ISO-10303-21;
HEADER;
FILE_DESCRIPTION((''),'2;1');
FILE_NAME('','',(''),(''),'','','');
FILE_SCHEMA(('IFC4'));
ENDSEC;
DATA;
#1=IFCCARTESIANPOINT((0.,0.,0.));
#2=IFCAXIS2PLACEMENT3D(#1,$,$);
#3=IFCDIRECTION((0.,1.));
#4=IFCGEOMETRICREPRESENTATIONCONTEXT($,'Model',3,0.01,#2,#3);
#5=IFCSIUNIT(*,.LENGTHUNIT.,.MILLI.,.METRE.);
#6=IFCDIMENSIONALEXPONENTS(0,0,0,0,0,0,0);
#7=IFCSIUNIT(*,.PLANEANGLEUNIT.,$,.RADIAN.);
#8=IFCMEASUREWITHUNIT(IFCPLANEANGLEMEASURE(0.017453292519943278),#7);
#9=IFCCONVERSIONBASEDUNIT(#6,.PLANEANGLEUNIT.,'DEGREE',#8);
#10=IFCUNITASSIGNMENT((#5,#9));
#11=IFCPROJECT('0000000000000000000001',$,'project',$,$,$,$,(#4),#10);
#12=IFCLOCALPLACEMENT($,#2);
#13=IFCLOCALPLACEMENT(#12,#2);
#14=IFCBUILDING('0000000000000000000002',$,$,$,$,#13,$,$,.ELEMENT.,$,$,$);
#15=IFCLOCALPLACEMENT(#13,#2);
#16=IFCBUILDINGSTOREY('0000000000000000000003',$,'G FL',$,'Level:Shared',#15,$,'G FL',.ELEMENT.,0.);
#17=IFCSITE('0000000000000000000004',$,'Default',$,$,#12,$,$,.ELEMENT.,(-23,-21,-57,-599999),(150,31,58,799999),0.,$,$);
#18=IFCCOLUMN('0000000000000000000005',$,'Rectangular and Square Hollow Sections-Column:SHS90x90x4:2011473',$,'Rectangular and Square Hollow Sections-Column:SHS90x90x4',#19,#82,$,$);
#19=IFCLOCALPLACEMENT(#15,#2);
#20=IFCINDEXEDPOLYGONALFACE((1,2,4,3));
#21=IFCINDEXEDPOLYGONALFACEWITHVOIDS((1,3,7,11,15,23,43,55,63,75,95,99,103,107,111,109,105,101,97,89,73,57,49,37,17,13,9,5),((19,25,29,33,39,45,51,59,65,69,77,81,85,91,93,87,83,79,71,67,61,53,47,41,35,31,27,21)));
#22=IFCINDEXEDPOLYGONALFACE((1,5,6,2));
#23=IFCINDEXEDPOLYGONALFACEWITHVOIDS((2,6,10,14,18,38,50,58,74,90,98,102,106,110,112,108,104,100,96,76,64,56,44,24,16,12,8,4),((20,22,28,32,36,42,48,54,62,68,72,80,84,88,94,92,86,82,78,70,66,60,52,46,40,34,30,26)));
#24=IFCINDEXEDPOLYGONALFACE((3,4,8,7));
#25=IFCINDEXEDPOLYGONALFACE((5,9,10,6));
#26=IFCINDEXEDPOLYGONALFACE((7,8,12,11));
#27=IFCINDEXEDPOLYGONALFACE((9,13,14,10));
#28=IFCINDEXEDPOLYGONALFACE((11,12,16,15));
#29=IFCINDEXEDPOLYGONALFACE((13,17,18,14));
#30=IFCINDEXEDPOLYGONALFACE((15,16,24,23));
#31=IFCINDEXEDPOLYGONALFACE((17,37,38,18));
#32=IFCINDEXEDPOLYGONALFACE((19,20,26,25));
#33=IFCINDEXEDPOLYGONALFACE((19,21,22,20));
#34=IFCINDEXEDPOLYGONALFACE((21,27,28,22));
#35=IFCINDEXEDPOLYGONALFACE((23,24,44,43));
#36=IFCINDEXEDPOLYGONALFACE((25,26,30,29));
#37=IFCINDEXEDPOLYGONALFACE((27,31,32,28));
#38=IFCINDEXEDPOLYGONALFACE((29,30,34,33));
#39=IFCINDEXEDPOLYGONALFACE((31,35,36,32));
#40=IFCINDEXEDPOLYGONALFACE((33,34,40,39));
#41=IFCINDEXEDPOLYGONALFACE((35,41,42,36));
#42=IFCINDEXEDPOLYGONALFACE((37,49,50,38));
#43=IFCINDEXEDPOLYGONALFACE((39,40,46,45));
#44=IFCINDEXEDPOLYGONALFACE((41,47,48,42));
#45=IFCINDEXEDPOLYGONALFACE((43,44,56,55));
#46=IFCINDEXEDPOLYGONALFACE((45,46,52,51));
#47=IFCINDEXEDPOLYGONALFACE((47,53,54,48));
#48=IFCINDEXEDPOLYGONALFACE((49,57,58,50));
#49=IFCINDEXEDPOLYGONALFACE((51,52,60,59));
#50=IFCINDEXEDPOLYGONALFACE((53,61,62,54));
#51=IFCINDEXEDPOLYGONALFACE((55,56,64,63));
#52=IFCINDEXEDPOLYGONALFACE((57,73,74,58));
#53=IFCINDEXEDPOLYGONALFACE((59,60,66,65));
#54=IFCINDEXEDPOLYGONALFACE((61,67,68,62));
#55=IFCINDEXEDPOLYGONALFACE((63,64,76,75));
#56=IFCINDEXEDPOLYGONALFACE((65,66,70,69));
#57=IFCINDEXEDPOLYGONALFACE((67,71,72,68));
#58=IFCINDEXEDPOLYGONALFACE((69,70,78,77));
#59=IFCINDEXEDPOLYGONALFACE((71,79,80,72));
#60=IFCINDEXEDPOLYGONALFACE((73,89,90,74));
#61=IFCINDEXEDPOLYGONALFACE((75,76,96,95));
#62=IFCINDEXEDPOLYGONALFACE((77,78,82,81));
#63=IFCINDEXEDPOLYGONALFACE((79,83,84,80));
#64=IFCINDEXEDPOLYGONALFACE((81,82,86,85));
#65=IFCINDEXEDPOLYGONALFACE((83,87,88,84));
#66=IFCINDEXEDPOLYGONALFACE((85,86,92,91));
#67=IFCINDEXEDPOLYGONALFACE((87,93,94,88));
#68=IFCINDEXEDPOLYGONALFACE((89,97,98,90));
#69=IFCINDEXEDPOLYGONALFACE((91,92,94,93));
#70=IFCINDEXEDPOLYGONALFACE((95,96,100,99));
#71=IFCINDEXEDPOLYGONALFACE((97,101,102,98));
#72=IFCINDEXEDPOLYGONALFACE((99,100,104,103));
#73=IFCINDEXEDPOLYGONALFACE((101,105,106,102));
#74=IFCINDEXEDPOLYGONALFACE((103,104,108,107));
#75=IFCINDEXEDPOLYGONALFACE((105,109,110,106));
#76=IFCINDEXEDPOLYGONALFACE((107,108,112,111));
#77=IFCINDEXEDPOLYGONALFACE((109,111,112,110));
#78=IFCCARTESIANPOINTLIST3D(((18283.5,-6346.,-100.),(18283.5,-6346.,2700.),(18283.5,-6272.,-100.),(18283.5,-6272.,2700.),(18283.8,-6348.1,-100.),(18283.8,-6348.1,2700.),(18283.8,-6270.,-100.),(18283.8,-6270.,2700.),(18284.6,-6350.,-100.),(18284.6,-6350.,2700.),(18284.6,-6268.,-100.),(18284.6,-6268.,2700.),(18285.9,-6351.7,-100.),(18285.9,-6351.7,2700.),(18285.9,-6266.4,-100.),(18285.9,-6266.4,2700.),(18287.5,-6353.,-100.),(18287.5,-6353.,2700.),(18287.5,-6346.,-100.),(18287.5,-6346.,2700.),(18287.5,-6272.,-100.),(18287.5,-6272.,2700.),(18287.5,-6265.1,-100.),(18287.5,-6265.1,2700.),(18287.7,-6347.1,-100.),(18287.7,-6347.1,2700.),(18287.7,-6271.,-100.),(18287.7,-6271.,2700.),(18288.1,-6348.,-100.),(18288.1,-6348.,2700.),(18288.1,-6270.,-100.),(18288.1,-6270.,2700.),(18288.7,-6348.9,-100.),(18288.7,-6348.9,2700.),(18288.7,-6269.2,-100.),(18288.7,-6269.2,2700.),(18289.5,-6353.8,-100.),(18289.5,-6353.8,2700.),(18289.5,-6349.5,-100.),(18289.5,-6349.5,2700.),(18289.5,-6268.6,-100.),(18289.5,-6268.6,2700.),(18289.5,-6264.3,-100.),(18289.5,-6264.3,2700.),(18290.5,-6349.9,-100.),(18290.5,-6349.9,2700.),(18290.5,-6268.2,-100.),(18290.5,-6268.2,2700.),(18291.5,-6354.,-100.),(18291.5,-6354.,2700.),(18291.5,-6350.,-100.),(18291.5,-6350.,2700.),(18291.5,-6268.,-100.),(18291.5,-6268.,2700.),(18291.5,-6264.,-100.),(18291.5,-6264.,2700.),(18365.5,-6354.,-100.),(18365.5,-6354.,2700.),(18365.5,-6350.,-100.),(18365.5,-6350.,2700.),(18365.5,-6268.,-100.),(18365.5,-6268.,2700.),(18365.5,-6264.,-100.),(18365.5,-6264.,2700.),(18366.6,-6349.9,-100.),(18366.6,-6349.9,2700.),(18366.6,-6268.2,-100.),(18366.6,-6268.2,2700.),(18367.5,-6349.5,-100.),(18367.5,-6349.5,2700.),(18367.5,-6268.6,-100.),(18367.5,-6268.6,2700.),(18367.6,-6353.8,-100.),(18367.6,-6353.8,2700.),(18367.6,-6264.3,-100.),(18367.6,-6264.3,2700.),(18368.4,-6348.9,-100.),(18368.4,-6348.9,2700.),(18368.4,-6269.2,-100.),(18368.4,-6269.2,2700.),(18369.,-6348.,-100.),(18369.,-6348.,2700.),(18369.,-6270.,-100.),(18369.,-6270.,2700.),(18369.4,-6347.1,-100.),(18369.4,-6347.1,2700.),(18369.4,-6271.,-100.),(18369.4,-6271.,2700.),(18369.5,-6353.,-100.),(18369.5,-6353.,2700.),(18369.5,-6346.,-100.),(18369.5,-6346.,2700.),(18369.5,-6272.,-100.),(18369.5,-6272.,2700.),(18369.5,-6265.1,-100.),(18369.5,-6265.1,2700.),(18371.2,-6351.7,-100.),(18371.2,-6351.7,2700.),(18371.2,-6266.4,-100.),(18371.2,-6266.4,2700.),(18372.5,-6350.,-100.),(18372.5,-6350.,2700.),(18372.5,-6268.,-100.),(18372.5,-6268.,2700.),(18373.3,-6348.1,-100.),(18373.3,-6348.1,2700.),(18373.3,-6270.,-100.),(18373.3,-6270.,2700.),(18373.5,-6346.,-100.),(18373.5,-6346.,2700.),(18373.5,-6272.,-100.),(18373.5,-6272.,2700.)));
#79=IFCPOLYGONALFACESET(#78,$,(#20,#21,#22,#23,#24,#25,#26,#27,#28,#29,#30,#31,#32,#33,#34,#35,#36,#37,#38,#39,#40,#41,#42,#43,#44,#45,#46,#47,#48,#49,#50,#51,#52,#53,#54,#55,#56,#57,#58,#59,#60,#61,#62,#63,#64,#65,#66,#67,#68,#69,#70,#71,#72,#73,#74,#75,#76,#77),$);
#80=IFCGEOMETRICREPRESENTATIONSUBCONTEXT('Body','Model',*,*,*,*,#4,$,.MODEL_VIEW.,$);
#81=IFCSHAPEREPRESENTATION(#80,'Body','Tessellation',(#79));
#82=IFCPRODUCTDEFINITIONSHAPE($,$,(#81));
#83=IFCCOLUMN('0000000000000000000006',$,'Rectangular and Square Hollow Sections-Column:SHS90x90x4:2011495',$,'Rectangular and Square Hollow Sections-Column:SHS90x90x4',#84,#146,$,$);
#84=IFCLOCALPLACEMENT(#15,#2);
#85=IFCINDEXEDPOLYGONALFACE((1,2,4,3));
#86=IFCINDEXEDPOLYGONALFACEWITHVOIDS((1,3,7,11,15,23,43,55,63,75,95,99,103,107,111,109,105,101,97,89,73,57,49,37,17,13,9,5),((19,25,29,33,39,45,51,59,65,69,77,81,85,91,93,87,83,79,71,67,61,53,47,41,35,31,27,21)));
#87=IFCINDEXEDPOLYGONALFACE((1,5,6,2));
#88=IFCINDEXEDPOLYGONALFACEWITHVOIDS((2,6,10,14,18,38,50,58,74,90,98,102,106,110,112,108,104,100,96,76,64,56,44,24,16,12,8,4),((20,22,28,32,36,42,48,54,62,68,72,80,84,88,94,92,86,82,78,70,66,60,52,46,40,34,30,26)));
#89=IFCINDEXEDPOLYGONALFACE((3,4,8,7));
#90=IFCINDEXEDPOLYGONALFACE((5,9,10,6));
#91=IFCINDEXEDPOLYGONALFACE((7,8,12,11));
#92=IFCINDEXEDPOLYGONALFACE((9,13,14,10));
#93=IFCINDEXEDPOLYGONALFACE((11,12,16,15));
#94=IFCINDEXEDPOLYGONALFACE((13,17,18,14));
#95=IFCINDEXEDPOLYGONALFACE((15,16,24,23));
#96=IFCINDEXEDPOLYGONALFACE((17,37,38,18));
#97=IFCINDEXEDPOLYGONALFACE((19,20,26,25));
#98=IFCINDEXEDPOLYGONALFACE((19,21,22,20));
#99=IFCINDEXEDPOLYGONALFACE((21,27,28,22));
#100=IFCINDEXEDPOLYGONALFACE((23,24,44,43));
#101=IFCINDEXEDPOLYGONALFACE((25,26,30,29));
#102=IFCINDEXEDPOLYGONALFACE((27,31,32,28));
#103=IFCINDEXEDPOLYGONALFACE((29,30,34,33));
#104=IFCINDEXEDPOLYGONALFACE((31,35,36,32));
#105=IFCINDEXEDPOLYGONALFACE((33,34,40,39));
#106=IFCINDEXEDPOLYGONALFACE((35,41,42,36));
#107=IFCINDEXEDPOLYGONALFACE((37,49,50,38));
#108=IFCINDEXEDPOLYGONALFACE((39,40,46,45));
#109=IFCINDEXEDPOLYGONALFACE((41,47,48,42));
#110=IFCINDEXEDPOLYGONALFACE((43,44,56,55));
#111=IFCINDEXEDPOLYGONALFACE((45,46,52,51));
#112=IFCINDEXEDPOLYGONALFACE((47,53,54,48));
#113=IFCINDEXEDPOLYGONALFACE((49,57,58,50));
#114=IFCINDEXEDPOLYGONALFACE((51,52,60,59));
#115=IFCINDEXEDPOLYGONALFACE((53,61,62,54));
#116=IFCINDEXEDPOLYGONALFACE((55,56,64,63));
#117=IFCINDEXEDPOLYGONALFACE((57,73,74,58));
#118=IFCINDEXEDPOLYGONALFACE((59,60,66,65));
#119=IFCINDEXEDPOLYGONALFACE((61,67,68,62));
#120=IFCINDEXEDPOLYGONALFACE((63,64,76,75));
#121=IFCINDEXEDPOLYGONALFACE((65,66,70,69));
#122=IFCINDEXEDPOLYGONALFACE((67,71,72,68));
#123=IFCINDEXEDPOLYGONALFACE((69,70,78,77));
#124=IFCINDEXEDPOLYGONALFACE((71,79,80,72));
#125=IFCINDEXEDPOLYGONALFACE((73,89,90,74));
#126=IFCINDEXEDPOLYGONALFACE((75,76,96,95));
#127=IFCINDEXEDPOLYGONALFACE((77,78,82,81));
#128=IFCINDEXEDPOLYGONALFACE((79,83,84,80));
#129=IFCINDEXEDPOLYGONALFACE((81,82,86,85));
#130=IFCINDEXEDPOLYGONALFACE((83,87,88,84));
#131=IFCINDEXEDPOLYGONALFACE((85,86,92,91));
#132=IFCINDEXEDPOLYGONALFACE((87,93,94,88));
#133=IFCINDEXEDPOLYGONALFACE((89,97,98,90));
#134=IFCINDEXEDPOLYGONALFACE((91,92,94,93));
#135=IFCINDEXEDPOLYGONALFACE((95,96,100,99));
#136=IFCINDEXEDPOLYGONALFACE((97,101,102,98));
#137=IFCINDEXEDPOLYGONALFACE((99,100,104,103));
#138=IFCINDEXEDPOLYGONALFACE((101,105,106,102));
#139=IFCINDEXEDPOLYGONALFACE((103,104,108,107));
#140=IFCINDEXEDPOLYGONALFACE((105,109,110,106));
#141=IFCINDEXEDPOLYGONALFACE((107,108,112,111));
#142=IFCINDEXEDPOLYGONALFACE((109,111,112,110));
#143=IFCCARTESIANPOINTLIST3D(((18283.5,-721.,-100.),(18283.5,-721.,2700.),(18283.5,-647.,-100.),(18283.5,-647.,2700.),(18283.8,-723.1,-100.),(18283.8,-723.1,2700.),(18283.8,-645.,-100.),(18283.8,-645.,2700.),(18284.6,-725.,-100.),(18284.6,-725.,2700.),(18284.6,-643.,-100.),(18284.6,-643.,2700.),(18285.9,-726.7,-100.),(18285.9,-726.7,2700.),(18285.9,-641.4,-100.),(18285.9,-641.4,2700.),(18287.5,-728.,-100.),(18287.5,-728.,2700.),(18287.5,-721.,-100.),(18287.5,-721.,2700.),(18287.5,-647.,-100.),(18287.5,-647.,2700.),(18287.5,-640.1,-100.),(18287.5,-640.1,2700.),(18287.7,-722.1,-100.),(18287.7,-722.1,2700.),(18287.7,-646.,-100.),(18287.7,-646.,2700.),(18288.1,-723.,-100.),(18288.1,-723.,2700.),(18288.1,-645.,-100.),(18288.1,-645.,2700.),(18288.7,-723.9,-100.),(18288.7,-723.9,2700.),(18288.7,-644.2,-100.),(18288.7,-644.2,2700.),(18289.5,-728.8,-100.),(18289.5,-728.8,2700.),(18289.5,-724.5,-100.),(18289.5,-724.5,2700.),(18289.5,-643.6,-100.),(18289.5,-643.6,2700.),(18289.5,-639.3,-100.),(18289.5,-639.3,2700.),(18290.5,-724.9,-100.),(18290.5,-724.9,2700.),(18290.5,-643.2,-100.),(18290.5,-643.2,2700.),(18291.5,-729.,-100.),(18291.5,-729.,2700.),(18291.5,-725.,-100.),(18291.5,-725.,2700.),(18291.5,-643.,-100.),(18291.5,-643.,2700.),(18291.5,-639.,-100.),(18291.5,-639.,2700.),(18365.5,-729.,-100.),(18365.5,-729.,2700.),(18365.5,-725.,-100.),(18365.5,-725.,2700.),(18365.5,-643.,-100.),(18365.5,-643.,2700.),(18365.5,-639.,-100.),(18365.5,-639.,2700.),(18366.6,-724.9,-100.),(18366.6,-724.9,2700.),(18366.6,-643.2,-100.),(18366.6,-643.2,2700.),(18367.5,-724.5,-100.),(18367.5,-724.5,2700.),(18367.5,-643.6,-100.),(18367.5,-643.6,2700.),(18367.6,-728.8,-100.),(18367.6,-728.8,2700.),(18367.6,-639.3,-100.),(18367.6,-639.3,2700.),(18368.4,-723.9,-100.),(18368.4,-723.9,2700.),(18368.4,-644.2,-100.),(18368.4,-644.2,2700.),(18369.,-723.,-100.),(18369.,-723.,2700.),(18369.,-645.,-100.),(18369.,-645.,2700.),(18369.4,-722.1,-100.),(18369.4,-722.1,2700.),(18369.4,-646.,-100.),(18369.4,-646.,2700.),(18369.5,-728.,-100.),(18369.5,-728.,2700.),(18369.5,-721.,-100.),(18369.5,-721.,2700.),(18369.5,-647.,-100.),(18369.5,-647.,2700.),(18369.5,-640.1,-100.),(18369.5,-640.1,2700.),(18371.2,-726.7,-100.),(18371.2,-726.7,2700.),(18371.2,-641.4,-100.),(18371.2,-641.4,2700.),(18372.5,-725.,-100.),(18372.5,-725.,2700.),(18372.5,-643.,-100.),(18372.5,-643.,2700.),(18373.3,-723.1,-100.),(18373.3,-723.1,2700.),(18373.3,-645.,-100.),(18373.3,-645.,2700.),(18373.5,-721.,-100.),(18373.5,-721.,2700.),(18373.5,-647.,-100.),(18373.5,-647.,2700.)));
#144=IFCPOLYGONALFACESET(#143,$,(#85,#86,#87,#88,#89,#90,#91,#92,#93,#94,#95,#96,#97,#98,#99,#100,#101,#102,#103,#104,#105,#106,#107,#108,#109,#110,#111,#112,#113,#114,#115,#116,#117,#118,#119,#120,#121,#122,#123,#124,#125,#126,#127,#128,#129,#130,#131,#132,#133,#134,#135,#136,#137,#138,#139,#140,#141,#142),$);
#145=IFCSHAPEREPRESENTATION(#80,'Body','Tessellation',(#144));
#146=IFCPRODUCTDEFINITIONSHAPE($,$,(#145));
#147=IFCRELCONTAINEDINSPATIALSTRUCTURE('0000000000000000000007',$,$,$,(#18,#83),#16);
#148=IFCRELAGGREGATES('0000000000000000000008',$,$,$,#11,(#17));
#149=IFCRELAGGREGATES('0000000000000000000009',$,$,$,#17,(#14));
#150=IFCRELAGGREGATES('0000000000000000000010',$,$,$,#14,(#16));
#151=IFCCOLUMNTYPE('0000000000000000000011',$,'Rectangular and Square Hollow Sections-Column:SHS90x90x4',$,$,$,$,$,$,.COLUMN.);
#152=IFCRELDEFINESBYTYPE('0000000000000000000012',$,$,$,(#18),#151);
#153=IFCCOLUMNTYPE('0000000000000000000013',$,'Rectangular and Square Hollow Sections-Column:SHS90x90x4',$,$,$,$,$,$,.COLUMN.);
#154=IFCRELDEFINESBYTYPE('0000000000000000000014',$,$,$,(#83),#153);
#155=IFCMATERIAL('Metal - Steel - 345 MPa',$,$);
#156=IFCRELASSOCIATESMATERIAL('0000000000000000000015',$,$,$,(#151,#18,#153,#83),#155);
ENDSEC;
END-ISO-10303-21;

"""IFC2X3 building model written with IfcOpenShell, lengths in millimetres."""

from ifc_helpers import new_model, entity, si_unit, converted_unit, direction, frame, frame_2d, origin, place, context, subcontext, project, spatial, polyline, circle_curve, parameter, trimmed, segment, composite_curve, outline, extrude, source, transform, mapped, material, type_object, type_shapes, element, save


model = new_model("IFC2X3")

# Units and contexts
model_context = context("Model", 3, precision=0.01, world=origin(), true_north=direction((0.0, 1.0)))
body_context = subcontext(model_context, "Body", "Model", "MODEL_VIEW")
ifc_project = project(units=[si_unit("LENGTHUNIT", "METRE", prefix="MILLI"), converted_unit("PLANEANGLEUNIT", "DEGREE", entity("IfcPlaneAngleMeasure", 0.017453292519943278), si_unit("PLANEANGLEUNIT", "RADIAN"), dimensions=[0, 0, 0, 0, 0, 0, 0])], contexts=[model_context])

# Site, building, storey
site_placement = place(None, origin())
site = spatial("IfcSite", under=ifc_project, at=site_placement, Name="Default", CompositionType="ELEMENT", RefLatitude=(-23, -21, -57, -599999), RefLongitude=(150, 31, 58, 799999), RefElevation=0.0)
building_placement = place(site_placement, origin())
building = spatial("IfcBuilding", under=site, at=building_placement, CompositionType="ELEMENT")
storey_placement = place(building_placement, origin())
storey = spatial("IfcBuildingStorey", under=building, at=storey_placement, Name="G FL", ObjectType="Level:Shared", LongName="G FL", CompositionType="ELEMENT", Elevation=0.0)

# Columns
ifc_material_1 = material(Name="Metal - Steel - 345 MPa")
column_type_1 = type_object("IfcColumnType", Name="Rectangular and Square Hollow Sections-Column:SHS90x90x4", PredefinedType="COLUMN", material=ifc_material_1)
shared_shape_1 = source(origin(), body_context, "Body", "SweptSolid", [
    extrude(outline(composite_curve([segment(polyline([(-37.0, -45.0), (37.0, -45.0)]), True, "CONTINUOUS"), segment(trimmed(circle_curve(frame_2d((37.0, -37.0), x_axis=(-1.0, 0.0)), 8.0), [parameter(90.0)], [parameter(180.0)], True, "PARAMETER"), True, "CONTINUOUS"), segment(polyline([(45.0, -37.0), (45.0, 37.0)]), True, "CONTINUOUS"), segment(trimmed(circle_curve(frame_2d((37.0, 37.0), x_axis=(-1.0, 0.0)), 8.0), [parameter(180.0)], [parameter(270.0)], True, "PARAMETER"), True, "CONTINUOUS"), segment(polyline([(37.0, 45.0), (-37.0, 45.0)]), True, "CONTINUOUS"), segment(trimmed(circle_curve(frame_2d((-37.0, 37.0), x_axis=(-1.0, 0.0)), 8.0), [parameter(270.0)], [parameter(360.0)], True, "PARAMETER"), True, "CONTINUOUS"), segment(polyline([(-45.0, 37.0), (-45.0, -37.0)]), True, "CONTINUOUS"), segment(trimmed(circle_curve(frame_2d((-37.0, -37.0), x_axis=(-1.0, 0.0)), 8.0), [parameter(360.0)], [parameter(90.0)], True, "PARAMETER"), True, "CONTINUOUS")], self_intersect=False), holes=[composite_curve([segment(trimmed(circle_curve(frame_2d((-37.0, -37.0), x_axis=(-1.0, 0.0)), 4.0), [parameter(0.0)], [parameter(90.0)], True, "PARAMETER"), False, "CONTINUOUS"), segment(polyline([(-41.0, -37.0), (-41.0, 37.0)]), True, "CONTINUOUS"), segment(trimmed(circle_curve(frame_2d((-37.0, 37.0), x_axis=(-1.0, 0.0)), 4.0), [parameter(270.0)], [parameter(360.0)], True, "PARAMETER"), False, "CONTINUOUS"), segment(polyline([(-37.0, 41.0), (37.0, 41.0)]), True, "CONTINUOUS"), segment(trimmed(circle_curve(frame_2d((37.0, 37.0), x_axis=(-1.0, 0.0)), 4.0), [parameter(180.0)], [parameter(270.0)], True, "PARAMETER"), False, "CONTINUOUS"), segment(polyline([(41.0, 37.0), (41.0, -37.0)]), True, "CONTINUOUS"), segment(trimmed(circle_curve(frame_2d((37.0, -37.0), x_axis=(-1.0, 0.0)), 4.0), [parameter(90.0)], [parameter(180.0)], True, "PARAMETER"), False, "CONTINUOUS"), segment(polyline([(37.0, -41.0), (-37.0, -41.0)]), True, "CONTINUOUS")], self_intersect=False)]), frame((18328.5, -6309.0, -100.0), z_axis=(0.0, 0.0, 1.0), x_axis=(-1.0, 0.0, 0.0)), (0.0, 0.0, 1.0), 2800.0),
])
type_shapes(column_type_1, [shared_shape_1])
column_1_placement = place(storey_placement, origin())
element("IfcColumn", 1, at=column_1_placement, inside=storey, type_object=column_type_1, material=ifc_material_1, Name="Rectangular and Square Hollow Sections-Column:SHS90x90x4:2011473", ObjectType="Rectangular and Square Hollow Sections-Column:SHS90x90x4", context=body_context, shape_type="MappedRepresentation", body=[
    mapped(shared_shape_1, transform((0.0, 0.0, 0.0), scale=1.0)),
])
column_type_2 = type_object("IfcColumnType", Name="Rectangular and Square Hollow Sections-Column:SHS90x90x4", PredefinedType="COLUMN", material=ifc_material_1)
shared_shape_2 = source(origin(), body_context, "Body", "SweptSolid", [
    extrude(outline(composite_curve([segment(polyline([(-37.0, -45.0), (37.0, -45.0)]), True, "CONTINUOUS"), segment(trimmed(circle_curve(frame_2d((37.0, -37.0), x_axis=(-1.0, 0.0)), 8.0), [parameter(90.0)], [parameter(180.0)], True, "PARAMETER"), True, "CONTINUOUS"), segment(polyline([(45.0, -37.0), (45.0, 37.0)]), True, "CONTINUOUS"), segment(trimmed(circle_curve(frame_2d((37.0, 37.0), x_axis=(-1.0, 0.0)), 8.0), [parameter(180.0)], [parameter(270.0)], True, "PARAMETER"), True, "CONTINUOUS"), segment(polyline([(37.0, 45.0), (-37.0, 45.0)]), True, "CONTINUOUS"), segment(trimmed(circle_curve(frame_2d((-37.0, 37.0), x_axis=(-1.0, 0.0)), 8.0), [parameter(270.0)], [parameter(360.0)], True, "PARAMETER"), True, "CONTINUOUS"), segment(polyline([(-45.0, 37.0), (-45.0, -37.0)]), True, "CONTINUOUS"), segment(trimmed(circle_curve(frame_2d((-37.0, -37.0), x_axis=(-1.0, 0.0)), 8.0), [parameter(360.0)], [parameter(90.0)], True, "PARAMETER"), True, "CONTINUOUS")], self_intersect=False), holes=[composite_curve([segment(trimmed(circle_curve(frame_2d((-37.0, -37.0), x_axis=(-1.0, 0.0)), 4.0), [parameter(0.0)], [parameter(90.0)], True, "PARAMETER"), False, "CONTINUOUS"), segment(polyline([(-41.0, -37.0), (-41.0, 37.0)]), True, "CONTINUOUS"), segment(trimmed(circle_curve(frame_2d((-37.0, 37.0), x_axis=(-1.0, 0.0)), 4.0), [parameter(270.0)], [parameter(360.0)], True, "PARAMETER"), False, "CONTINUOUS"), segment(polyline([(-37.0, 41.0), (37.0, 41.0)]), True, "CONTINUOUS"), segment(trimmed(circle_curve(frame_2d((37.0, 37.0), x_axis=(-1.0, 0.0)), 4.0), [parameter(180.0)], [parameter(270.0)], True, "PARAMETER"), False, "CONTINUOUS"), segment(polyline([(41.0, 37.0), (41.0, -37.0)]), True, "CONTINUOUS"), segment(trimmed(circle_curve(frame_2d((37.0, -37.0), x_axis=(-1.0, 0.0)), 4.0), [parameter(90.0)], [parameter(180.0)], True, "PARAMETER"), False, "CONTINUOUS"), segment(polyline([(37.0, -41.0), (-37.0, -41.0)]), True, "CONTINUOUS")], self_intersect=False)]), frame((18328.5, -684.0, -100.0), z_axis=(0.0, 0.0, 1.0), x_axis=(-1.0, 0.0, 0.0)), (0.0, 0.0, 1.0), 2800.0),
])
type_shapes(column_type_2, [shared_shape_2])
column_2_placement = place(storey_placement, origin())
element("IfcColumn", 2, at=column_2_placement, inside=storey, type_object=column_type_2, material=ifc_material_1, Name="Rectangular and Square Hollow Sections-Column:SHS90x90x4:2011495", ObjectType="Rectangular and Square Hollow Sections-Column:SHS90x90x4", context=body_context, shape_type="MappedRepresentation", body=[
    mapped(shared_shape_2, transform((0.0, 0.0, 0.0), scale=1.0)),
])

save(model, "model.ifc")
